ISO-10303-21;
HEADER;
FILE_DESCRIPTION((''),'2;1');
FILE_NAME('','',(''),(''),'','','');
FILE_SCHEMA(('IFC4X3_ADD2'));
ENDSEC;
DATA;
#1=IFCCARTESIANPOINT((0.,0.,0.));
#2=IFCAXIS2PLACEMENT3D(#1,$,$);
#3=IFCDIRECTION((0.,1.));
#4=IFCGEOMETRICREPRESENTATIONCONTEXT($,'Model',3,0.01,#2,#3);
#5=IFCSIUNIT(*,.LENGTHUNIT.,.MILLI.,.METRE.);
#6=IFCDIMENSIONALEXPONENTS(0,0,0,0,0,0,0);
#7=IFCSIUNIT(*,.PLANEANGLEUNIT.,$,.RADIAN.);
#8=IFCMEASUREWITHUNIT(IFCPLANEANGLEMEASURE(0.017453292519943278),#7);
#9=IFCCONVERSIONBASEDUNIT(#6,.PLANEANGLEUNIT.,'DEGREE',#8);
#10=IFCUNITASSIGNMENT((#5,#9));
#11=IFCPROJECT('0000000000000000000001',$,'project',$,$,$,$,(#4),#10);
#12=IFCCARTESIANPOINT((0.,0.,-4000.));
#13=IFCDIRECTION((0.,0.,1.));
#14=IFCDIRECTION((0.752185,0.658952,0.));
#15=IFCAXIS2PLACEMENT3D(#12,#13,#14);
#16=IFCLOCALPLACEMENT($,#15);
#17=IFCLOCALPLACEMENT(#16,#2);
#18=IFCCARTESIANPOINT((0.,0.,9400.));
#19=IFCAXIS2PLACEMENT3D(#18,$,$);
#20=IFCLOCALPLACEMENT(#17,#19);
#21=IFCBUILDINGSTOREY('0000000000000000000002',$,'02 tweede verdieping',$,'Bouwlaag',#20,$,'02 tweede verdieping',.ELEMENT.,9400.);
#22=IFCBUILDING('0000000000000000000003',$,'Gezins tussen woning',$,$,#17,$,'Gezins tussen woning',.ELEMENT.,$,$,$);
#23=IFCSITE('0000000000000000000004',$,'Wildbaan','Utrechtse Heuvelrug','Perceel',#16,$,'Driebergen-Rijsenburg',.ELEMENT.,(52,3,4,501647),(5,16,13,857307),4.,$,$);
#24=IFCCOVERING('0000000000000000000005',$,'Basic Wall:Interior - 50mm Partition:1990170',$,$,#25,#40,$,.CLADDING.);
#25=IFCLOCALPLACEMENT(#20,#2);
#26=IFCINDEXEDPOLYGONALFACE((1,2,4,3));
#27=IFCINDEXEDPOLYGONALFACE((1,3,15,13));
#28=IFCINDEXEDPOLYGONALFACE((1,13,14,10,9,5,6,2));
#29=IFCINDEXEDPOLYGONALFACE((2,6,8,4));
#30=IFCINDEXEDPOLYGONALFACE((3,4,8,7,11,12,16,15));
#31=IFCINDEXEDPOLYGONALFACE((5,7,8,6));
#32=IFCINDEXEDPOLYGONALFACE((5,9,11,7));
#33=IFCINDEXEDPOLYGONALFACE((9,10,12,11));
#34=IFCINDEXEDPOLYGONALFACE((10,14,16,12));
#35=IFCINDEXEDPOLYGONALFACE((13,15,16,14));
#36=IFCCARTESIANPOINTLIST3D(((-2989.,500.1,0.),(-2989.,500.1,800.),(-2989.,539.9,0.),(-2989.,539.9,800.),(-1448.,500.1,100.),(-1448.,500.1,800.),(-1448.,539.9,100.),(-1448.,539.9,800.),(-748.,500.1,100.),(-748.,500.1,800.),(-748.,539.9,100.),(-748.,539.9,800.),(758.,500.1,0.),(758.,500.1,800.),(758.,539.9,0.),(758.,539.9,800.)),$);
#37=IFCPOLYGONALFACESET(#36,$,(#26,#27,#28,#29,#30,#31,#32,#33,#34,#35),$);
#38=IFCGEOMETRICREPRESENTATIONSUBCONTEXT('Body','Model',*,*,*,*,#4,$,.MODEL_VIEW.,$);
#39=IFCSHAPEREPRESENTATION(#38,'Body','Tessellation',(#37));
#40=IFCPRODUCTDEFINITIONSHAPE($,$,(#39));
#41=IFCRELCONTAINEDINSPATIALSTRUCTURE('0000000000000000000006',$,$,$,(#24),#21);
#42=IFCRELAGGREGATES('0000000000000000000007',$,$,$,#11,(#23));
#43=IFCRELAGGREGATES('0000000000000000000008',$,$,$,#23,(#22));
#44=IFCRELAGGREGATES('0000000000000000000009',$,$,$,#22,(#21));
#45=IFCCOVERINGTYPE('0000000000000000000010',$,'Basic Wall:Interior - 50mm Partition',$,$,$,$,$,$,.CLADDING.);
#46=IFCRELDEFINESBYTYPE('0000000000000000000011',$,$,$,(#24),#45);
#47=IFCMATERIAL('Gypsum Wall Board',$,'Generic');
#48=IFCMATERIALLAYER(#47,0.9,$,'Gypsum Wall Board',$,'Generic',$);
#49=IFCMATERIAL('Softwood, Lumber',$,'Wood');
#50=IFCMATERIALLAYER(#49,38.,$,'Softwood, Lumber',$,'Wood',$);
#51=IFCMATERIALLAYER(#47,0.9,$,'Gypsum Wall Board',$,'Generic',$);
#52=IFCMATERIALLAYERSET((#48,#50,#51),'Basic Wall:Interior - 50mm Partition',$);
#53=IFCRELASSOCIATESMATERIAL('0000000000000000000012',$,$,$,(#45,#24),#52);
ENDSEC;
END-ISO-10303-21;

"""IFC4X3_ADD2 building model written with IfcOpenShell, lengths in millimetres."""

from ifc_helpers import new_model, entity, si_unit, converted_unit, direction, frame, frame_2d, origin, place, context, subcontext, project, spatial, rectangle, extrude, material, layer, layer_set, layer_usage, type_object, element, save


model = new_model("IFC4X3_ADD2")

# Units and contexts
model_context = context("Model", 3, precision=0.01, world=origin(), true_north=direction((0.0, 1.0)))
body_context = subcontext(model_context, "Body", "Model", "MODEL_VIEW")
ifc_project = project(units=[si_unit("LENGTHUNIT", "METRE", prefix="MILLI"), converted_unit("PLANEANGLEUNIT", "DEGREE", entity("IfcPlaneAngleMeasure", 0.017453292519943278), si_unit("PLANEANGLEUNIT", "RADIAN"), dimensions=[0, 0, 0, 0, 0, 0, 0])], contexts=[model_context])

# Site, building, storey
site_placement = place(None, frame((0.0, 0.0, -4000.0), z_axis=(0.0, 0.0, 1.0), x_axis=(0.752185, 0.658952, 0.0)))
site = spatial("IfcSite", under=ifc_project, at=site_placement, Name="Wildbaan", Description="Utrechtse Heuvelrug", ObjectType="Perceel", LongName="Driebergen-Rijsenburg", CompositionType="ELEMENT", RefLatitude=(52, 3, 4, 501647), RefLongitude=(5, 16, 13, 857307), RefElevation=4.0)
building_placement = place(site_placement, origin())
building = spatial("IfcBuilding", under=site, at=building_placement, Name="Gezins tussen woning", LongName="Gezins tussen woning", CompositionType="ELEMENT")
storey_placement = place(building_placement, frame((0.0, 0.0, 9400.0)))
storey = spatial("IfcBuildingStorey", under=building, at=storey_placement, Name="02 tweede verdieping", ObjectType="Bouwlaag", LongName="02 tweede verdieping", CompositionType="ELEMENT", Elevation=9400.0)

# Shared definitions
ifc_material_1 = material(Name="Gypsum Wall Board", Category="Generic")
ifc_material_2 = material(Name="Softwood, Lumber", Category="Wood")

# Covering, opening
ifc_layer_1 = layer(ifc_material_1, 0.9, Name="Gypsum Wall Board", Category="Generic")
ifc_layer_2 = layer(ifc_material_2, 38.0, Name="Softwood, Lumber", Category="Wood")
ifc_layer_3 = layer(ifc_material_1, 0.9, Name="Gypsum Wall Board", Category="Generic")
ifc_layer_set_1 = layer_set([ifc_layer_1, ifc_layer_2, ifc_layer_3], Name="Basic Wall:Interior - 50mm Partition")
ifc_layer_usage_1 = layer_usage(ifc_layer_set_1, "AXIS2", "NEGATIVE", 19.9)
covering_type_1 = type_object("IfcCoveringType", Name="Basic Wall:Interior - 50mm Partition", PredefinedType="CLADDING", material=ifc_layer_set_1)
covering_1_placement = place(storey_placement, frame((-2989.0, 520.0, 0.0)))
covering_1 = element("IfcCovering", 1, at=covering_1_placement, inside=storey, type_object=covering_type_1, material=ifc_layer_usage_1, Name="Basic Wall:Interior - 50mm Partition:1990170", PredefinedType="CLADDING", context=body_context, shape_type="SweptSolid", body=[
    extrude(rectangle(XDim=3747.0, YDim=39.8, at=frame_2d((1873.5, 0.0), x_axis=(-1.0, 0.0))), origin(), (0.0, 0.0, 1.0), 800.0),
])
opening_1_placement = place(covering_1_placement, frame((2989.0, -520.0, 100.0)))
element("IfcOpeningElement", 2, at=opening_1_placement, cuts=covering_1, PredefinedType="OPENING", context=body_context, shape_type="SweptSolid", body=[
    extrude(rectangle(XDim=700.0, YDim=700.0, at=frame_2d((0.0, 0.0), x_axis=(0.0, 1.0))), frame((-1098.0, 500.1, 350.0), z_axis=(0.0, 1.0, 0.0), x_axis=(1.0, 0.0, 0.0)), (0.0, 0.0, 1.0), 39.8),
])

save(model, "model.ifc")
